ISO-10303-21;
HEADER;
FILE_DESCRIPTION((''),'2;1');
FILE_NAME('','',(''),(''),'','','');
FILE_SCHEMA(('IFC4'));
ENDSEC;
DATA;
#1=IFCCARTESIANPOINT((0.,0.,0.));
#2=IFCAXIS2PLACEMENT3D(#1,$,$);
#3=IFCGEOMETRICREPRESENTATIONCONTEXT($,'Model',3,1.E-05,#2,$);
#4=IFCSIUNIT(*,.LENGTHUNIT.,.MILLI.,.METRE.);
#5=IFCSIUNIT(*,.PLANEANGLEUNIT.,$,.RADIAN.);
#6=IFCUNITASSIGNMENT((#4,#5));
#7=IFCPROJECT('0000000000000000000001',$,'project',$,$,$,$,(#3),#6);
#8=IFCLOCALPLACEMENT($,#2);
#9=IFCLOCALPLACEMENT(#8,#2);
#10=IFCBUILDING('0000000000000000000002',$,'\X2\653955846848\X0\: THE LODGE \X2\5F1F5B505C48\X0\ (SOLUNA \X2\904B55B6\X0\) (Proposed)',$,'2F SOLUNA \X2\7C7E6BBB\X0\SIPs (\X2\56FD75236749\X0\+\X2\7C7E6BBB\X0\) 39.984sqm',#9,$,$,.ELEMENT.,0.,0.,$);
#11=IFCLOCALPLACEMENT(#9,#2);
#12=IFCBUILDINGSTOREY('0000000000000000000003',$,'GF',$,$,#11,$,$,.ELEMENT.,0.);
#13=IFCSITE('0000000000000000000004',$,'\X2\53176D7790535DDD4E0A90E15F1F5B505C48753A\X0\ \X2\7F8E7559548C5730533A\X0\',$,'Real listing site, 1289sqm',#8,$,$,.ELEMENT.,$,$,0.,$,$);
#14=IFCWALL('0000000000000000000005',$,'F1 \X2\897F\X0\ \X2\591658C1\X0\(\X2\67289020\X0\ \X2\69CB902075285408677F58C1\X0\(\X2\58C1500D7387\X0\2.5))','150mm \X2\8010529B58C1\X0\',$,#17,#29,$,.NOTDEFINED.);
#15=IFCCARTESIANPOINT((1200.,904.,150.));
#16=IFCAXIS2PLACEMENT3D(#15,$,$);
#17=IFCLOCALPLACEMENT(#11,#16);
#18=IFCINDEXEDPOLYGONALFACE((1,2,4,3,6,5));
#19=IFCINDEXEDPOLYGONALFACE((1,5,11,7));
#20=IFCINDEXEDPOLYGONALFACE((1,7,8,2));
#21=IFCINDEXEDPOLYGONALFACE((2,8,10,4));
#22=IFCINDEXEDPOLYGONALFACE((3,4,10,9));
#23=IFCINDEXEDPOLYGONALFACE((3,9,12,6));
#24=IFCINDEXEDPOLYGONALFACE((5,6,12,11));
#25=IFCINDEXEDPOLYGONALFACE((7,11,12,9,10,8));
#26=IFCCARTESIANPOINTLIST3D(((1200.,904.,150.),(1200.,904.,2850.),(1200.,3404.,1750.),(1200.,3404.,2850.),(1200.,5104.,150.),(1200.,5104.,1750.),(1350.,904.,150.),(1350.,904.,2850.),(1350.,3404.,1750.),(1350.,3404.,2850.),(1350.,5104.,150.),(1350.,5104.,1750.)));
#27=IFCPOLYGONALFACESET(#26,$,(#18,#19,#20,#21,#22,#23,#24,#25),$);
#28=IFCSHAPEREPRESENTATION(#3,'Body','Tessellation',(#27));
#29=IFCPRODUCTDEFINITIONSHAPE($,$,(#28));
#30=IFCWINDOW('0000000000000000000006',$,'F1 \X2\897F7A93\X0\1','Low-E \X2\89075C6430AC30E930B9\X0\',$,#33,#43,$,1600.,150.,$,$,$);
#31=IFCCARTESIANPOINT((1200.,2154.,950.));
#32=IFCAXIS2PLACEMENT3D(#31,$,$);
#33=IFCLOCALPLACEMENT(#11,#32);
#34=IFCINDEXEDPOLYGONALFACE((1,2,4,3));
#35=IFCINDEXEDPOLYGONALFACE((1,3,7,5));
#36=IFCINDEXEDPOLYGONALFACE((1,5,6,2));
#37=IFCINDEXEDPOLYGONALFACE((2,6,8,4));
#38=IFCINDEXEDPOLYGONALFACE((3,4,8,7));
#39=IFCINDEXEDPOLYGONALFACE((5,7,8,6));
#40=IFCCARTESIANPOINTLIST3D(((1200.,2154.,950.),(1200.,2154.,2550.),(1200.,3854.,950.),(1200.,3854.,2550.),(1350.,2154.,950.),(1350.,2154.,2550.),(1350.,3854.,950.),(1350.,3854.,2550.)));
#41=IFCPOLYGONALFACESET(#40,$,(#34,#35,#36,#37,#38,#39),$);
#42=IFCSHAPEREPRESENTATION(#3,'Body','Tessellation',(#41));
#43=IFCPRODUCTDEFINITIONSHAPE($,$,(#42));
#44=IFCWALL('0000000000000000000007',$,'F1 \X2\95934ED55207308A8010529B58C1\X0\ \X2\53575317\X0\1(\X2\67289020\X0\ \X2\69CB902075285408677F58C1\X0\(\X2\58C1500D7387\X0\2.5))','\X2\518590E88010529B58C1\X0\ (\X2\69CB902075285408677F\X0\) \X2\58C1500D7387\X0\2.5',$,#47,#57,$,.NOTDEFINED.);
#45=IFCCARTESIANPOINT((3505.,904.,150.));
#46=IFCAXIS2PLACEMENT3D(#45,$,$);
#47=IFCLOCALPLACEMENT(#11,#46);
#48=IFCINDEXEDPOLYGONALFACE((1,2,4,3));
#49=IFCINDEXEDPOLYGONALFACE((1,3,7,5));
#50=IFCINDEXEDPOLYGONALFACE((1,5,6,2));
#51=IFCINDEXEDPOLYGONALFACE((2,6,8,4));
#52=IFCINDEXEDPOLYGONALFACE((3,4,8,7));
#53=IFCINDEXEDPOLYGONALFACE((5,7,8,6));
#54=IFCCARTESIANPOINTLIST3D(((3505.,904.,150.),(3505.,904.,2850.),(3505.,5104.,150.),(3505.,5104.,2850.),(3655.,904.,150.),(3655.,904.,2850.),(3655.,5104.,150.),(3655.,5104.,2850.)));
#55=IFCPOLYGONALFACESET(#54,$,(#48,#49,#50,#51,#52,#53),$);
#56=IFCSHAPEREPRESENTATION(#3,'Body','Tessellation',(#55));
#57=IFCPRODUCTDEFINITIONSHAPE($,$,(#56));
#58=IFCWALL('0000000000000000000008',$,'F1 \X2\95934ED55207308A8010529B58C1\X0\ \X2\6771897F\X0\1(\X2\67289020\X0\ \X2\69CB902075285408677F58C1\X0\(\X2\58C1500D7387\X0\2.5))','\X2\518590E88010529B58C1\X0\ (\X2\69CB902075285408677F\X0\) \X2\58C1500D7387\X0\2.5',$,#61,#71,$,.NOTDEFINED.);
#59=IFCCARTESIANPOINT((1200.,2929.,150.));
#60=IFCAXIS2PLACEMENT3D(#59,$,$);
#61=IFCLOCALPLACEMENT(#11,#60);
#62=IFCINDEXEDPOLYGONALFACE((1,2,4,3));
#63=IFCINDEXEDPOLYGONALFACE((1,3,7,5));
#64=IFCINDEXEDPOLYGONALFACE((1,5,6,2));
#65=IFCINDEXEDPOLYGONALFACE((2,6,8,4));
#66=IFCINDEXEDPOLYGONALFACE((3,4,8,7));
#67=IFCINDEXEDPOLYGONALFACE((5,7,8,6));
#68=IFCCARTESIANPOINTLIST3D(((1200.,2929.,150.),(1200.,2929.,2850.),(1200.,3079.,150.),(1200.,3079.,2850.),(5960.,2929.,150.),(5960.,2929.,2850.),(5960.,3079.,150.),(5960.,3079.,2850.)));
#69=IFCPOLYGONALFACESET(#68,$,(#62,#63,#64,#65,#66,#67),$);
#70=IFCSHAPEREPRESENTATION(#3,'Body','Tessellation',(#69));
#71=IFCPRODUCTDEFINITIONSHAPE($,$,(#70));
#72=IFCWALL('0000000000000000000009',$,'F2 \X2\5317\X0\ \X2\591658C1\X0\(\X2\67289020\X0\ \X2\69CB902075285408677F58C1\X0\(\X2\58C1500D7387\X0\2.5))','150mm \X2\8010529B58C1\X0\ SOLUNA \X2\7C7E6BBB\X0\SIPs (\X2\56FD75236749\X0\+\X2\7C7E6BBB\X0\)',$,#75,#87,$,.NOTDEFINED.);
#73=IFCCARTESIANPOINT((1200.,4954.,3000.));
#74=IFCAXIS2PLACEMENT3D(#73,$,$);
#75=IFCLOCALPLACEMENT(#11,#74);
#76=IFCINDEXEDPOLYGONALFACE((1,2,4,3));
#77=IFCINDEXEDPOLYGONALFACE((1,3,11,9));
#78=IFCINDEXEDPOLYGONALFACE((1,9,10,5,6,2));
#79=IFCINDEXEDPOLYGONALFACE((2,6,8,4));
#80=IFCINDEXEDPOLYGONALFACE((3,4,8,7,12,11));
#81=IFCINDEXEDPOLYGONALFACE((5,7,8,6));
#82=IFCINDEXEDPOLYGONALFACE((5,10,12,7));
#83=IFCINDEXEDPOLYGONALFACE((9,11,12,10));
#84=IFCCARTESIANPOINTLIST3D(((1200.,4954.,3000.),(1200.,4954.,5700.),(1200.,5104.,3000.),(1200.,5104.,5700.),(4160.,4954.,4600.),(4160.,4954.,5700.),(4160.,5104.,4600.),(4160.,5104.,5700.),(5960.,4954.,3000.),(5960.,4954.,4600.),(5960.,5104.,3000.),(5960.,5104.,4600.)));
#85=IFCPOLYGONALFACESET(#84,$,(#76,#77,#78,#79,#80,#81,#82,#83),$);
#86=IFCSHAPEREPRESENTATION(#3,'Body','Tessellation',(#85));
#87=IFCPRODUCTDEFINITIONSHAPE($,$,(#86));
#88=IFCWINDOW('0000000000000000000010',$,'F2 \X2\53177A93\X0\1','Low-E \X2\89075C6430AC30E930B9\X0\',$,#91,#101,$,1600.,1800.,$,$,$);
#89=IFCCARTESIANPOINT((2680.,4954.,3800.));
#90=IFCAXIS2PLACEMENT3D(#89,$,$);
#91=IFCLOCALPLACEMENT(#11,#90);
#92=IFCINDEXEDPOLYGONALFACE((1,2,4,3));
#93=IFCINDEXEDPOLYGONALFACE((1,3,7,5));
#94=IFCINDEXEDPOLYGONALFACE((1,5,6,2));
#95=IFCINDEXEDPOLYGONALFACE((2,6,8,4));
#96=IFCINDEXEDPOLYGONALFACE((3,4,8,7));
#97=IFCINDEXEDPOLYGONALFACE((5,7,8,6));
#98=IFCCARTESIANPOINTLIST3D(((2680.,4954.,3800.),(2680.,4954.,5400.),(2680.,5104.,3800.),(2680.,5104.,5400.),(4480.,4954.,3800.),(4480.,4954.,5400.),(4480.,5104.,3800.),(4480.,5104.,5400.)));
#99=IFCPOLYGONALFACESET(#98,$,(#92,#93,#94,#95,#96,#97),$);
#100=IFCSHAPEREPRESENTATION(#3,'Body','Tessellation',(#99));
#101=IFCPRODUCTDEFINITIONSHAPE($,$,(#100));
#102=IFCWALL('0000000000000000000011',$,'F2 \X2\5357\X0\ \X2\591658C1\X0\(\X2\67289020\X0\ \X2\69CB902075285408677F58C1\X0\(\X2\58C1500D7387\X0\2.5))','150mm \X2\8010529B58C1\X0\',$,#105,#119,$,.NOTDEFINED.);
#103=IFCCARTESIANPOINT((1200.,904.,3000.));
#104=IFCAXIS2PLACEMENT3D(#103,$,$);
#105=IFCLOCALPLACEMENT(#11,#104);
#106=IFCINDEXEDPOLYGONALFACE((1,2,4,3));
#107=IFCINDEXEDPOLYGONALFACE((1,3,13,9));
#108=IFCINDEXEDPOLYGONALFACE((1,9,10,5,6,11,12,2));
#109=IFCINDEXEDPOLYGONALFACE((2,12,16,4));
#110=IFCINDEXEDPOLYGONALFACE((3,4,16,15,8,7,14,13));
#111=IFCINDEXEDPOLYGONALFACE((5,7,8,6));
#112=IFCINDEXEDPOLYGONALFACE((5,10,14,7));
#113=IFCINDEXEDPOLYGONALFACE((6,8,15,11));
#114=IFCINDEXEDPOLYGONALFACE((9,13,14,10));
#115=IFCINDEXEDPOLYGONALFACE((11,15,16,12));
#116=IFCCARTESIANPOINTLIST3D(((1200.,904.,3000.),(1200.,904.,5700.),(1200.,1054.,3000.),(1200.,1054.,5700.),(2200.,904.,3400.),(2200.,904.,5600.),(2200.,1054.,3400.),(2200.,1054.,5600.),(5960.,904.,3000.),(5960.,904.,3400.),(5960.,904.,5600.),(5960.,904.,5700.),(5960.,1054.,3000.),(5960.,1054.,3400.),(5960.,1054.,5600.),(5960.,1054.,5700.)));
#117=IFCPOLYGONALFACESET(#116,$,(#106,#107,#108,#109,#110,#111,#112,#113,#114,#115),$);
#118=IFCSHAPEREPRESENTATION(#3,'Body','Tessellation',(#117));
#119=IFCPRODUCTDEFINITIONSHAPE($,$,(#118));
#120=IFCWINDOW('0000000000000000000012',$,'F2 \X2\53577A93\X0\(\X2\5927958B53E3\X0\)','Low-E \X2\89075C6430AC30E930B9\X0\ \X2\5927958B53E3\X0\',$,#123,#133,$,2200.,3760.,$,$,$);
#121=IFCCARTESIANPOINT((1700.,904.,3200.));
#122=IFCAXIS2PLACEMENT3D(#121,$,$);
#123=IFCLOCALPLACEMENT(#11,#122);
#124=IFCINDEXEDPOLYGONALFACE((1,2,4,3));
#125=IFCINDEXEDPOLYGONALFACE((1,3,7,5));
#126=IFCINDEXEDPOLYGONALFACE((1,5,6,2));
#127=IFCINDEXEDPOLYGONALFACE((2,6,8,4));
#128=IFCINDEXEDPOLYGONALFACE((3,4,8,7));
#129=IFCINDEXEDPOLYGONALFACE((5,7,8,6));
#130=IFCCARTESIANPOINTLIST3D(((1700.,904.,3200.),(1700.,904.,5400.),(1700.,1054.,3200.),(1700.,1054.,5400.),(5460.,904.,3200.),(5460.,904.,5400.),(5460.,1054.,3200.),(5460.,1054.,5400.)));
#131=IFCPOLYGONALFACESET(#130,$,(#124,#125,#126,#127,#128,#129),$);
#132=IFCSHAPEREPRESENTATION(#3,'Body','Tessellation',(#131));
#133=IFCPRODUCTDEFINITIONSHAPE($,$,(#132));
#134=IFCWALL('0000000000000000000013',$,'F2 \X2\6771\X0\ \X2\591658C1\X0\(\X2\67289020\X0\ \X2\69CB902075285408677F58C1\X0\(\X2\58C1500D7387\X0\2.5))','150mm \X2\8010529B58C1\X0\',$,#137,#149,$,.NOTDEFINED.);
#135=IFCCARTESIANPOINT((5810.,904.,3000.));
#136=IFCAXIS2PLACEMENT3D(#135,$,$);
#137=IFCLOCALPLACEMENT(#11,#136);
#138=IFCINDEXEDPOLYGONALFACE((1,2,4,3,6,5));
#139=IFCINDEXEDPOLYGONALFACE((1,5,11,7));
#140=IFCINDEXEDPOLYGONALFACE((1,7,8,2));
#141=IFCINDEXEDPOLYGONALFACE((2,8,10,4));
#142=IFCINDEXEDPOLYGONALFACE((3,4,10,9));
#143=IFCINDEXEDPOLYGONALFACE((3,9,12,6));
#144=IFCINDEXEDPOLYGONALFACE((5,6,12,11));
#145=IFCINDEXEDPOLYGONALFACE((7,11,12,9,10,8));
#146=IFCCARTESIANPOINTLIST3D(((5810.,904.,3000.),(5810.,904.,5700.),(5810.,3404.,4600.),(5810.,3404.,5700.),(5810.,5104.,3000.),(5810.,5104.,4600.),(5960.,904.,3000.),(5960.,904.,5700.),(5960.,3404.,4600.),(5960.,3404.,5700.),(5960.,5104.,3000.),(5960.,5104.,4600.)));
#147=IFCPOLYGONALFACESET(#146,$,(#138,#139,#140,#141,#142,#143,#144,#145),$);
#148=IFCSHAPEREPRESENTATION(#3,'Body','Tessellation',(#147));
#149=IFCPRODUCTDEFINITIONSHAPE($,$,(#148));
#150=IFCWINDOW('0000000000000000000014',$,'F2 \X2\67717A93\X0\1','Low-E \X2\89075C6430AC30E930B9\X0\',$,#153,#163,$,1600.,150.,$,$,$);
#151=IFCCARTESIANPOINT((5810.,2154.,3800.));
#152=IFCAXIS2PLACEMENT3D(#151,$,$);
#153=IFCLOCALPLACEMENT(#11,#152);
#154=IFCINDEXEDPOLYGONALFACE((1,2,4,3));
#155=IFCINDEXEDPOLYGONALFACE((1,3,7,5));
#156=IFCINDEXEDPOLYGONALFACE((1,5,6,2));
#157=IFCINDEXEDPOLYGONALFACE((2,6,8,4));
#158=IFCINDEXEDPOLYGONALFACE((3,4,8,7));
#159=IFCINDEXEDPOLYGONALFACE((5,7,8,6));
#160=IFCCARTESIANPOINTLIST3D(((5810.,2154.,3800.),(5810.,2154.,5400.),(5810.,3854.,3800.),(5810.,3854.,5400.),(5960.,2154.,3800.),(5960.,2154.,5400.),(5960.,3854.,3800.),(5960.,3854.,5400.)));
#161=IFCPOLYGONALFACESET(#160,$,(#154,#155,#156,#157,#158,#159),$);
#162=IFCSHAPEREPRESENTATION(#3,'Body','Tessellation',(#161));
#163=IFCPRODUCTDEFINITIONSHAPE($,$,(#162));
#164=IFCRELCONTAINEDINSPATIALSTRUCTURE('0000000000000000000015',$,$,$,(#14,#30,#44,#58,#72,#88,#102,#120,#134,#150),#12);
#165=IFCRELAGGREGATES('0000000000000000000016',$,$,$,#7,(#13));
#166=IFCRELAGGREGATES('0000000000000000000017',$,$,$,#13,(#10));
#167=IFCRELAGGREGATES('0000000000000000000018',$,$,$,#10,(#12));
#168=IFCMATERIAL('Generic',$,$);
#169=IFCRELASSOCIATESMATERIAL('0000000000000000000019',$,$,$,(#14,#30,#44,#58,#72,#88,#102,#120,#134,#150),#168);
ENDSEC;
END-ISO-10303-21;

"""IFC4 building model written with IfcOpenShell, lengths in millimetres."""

from ifc_helpers import new_model, si_unit, frame, frame_2d, origin, place, context, project, spatial, rectangle, extrude, material, element, fill, save


model = new_model("IFC4")

# Units and contexts
model_context = context("Model", 3, precision=1e-05, world=origin())
ifc_project = project(units=[si_unit("LENGTHUNIT", "METRE", prefix="MILLI"), si_unit("PLANEANGLEUNIT", "RADIAN")], contexts=[model_context])

# Site, building, storey
site_placement = place(None, origin())
site = spatial("IfcSite", under=ifc_project, at=site_placement, Name="北海道川上郡弟子屈町 美留和地区", ObjectType="Real listing site, 1289sqm", CompositionType="ELEMENT", RefElevation=0.0)
building_placement = place(site_placement, origin())
building = spatial("IfcBuilding", under=site, at=building_placement, Name="改善案: THE LODGE 弟子屈 (SOLUNA 運営) (Proposed)", ObjectType="2F SOLUNA 籾殻SIPs (国産杉+籾殻) 39.984sqm", CompositionType="ELEMENT", ElevationOfRefHeight=0.0, ElevationOfTerrain=0.0)
storey_placement = place(building_placement, origin())
storey = spatial("IfcBuildingStorey", under=building, at=storey_placement, Name="GF", CompositionType="ELEMENT", Elevation=0.0)

# Shared definitions
ifc_material_1 = material(Name="Generic")

# Wall, opening, window
wall_1_placement = place(storey_placement, frame((1200.0, 904.0, 150.0)))
wall_1 = element("IfcWall", 1, at=wall_1_placement, inside=storey, material=ifc_material_1, Name="F1 西 外壁(木造 構造用合板壁(壁倍率2.5))", Description="150mm 耐力壁", PredefinedType="NOTDEFINED", context=model_context, shape_type="SweptSolid", body=[
    extrude(rectangle(XDim=150.0, YDim=4200.0, at=frame_2d((75.0, 2100.0))), frame((1200.0, 904.0, 150.0)), (0.0, 0.0, 1.0), 2700.0),
])
opening_1_placement = place(storey_placement, frame((1200.0, 2154.0, 950.0)))
opening_1 = element("IfcOpeningElement", 2, at=opening_1_placement, cuts=wall_1, PredefinedType="NOTDEFINED", context=model_context, shape_type="SweptSolid", body=[
    extrude(rectangle(XDim=150.0, YDim=1700.0, at=frame_2d((75.0, 850.0))), frame((1200.0, 2154.0, 950.0)), (0.0, 0.0, 1.0), 1600.0),
])
window_1_placement = place(storey_placement, frame((1200.0, 2154.0, 950.0)))
window_1 = element("IfcWindow", 3, at=window_1_placement, inside=storey, material=ifc_material_1, Name="F1 西窓1", Description="Low-E 複層ガラス", OverallHeight=1600.0, OverallWidth=150.0, context=model_context, shape_type="SweptSolid", body=[
    extrude(rectangle(XDim=150.0, YDim=1700.0, at=frame_2d((75.0, 850.0))), frame((1200.0, 2154.0, 950.0)), (0.0, 0.0, 1.0), 1600.0),
])
fill(opening_1, window_1)

# Walls
wall_2_placement = place(storey_placement, frame((3505.0, 904.0, 150.0)))
element("IfcWall", 4, at=wall_2_placement, inside=storey, material=ifc_material_1, Name="F1 間仕切り耐力壁 南北1(木造 構造用合板壁(壁倍率2.5))", Description="内部耐力壁 (構造用合板) 壁倍率2.5", PredefinedType="NOTDEFINED", context=model_context, shape_type="SweptSolid", body=[
    extrude(rectangle(XDim=150.0, YDim=4200.0, at=frame_2d((75.0, 2100.0))), frame((3505.0, 904.0, 150.0)), (0.0, 0.0, 1.0), 2700.0),
])
wall_3_placement = place(storey_placement, frame((1200.0, 2929.0, 150.0)))
element("IfcWall", 5, at=wall_3_placement, inside=storey, material=ifc_material_1, Name="F1 間仕切り耐力壁 東西1(木造 構造用合板壁(壁倍率2.5))", Description="内部耐力壁 (構造用合板) 壁倍率2.5", PredefinedType="NOTDEFINED", context=model_context, shape_type="SweptSolid", body=[
    extrude(rectangle(XDim=4760.0, YDim=150.0, at=frame_2d((2380.0, 75.0))), frame((1200.0, 2929.0, 150.0)), (0.0, 0.0, 1.0), 2700.0),
])

# Walls, openings, windows
wall_4_placement = place(storey_placement, frame((1200.0, 4954.0, 3000.0)))
wall_4 = element("IfcWall", 6, at=wall_4_placement, inside=storey, material=ifc_material_1, Name="F2 北 外壁(木造 構造用合板壁(壁倍率2.5))", Description="150mm 耐力壁 SOLUNA 籾殻SIPs (国産杉+籾殻)", PredefinedType="NOTDEFINED", context=model_context, shape_type="SweptSolid", body=[
    extrude(rectangle(XDim=4760.0, YDim=150.0, at=frame_2d((2380.0, 75.0))), frame((1200.0, 4954.0, 3000.0)), (0.0, 0.0, 1.0), 2700.0),
])
opening_2_placement = place(storey_placement, frame((2680.0, 4954.0, 3800.0)))
opening_2 = element("IfcOpeningElement", 7, at=opening_2_placement, cuts=wall_4, PredefinedType="NOTDEFINED", context=model_context, shape_type="SweptSolid", body=[
    extrude(rectangle(XDim=1800.0, YDim=150.0, at=frame_2d((900.0, 75.0))), frame((2680.0, 4954.0, 3800.0)), (0.0, 0.0, 1.0), 1600.0),
])
window_2_placement = place(storey_placement, frame((2680.0, 4954.0, 3800.0)))
window_2 = element("IfcWindow", 8, at=window_2_placement, inside=storey, material=ifc_material_1, Name="F2 北窓1", Description="Low-E 複層ガラス", OverallHeight=1600.0, OverallWidth=1800.0, context=model_context, shape_type="SweptSolid", body=[
    extrude(rectangle(XDim=1800.0, YDim=150.0, at=frame_2d((900.0, 75.0))), frame((2680.0, 4954.0, 3800.0)), (0.0, 0.0, 1.0), 1600.0),
])
fill(opening_2, window_2)
wall_5_placement = place(storey_placement, frame((1200.0, 904.0, 3000.0)))
wall_5 = element("IfcWall", 9, at=wall_5_placement, inside=storey, material=ifc_material_1, Name="F2 南 外壁(木造 構造用合板壁(壁倍率2.5))", Description="150mm 耐力壁", PredefinedType="NOTDEFINED", context=model_context, shape_type="SweptSolid", body=[
    extrude(rectangle(XDim=4760.0, YDim=150.0, at=frame_2d((2380.0, 75.0))), frame((1200.0, 904.0, 3000.0)), (0.0, 0.0, 1.0), 2700.0),
])
opening_3_placement = place(storey_placement, frame((1700.0, 904.0, 3200.0)))
opening_3 = element("IfcOpeningElement", 10, at=opening_3_placement, cuts=wall_5, PredefinedType="NOTDEFINED", context=model_context, shape_type="SweptSolid", body=[
    extrude(rectangle(XDim=3760.0, YDim=150.0, at=frame_2d((1880.0, 75.0))), frame((1700.0, 904.0, 3200.0)), (0.0, 0.0, 1.0), 2200.0),
])
window_3_placement = place(storey_placement, frame((1700.0, 904.0, 3200.0)))
window_3 = element("IfcWindow", 11, at=window_3_placement, inside=storey, material=ifc_material_1, Name="F2 南窓(大開口)", Description="Low-E 複層ガラス 大開口", OverallHeight=2200.0, OverallWidth=3760.0, context=model_context, shape_type="SweptSolid", body=[
    extrude(rectangle(XDim=3760.0, YDim=150.0, at=frame_2d((1880.0, 75.0))), frame((1700.0, 904.0, 3200.0)), (0.0, 0.0, 1.0), 2200.0),
])
fill(opening_3, window_3)
wall_6_placement = place(storey_placement, frame((5810.0, 904.0, 3000.0)))
wall_6 = element("IfcWall", 12, at=wall_6_placement, inside=storey, material=ifc_material_1, Name="F2 東 外壁(木造 構造用合板壁(壁倍率2.5))", Description="150mm 耐力壁", PredefinedType="NOTDEFINED", context=model_context, shape_type="SweptSolid", body=[
    extrude(rectangle(XDim=150.0, YDim=4200.0, at=frame_2d((75.0, 2100.0))), frame((5810.0, 904.0, 3000.0)), (0.0, 0.0, 1.0), 2700.0),
])
opening_4_placement = place(storey_placement, frame((5810.0, 2154.0, 3800.0)))
opening_4 = element("IfcOpeningElement", 13, at=opening_4_placement, cuts=wall_6, PredefinedType="NOTDEFINED", context=model_context, shape_type="SweptSolid", body=[
    extrude(rectangle(XDim=150.0, YDim=1700.0, at=frame_2d((75.0, 850.0))), frame((5810.0, 2154.0, 3800.0)), (0.0, 0.0, 1.0), 1600.0),
])
window_4_placement = place(storey_placement, frame((5810.0, 2154.0, 3800.0)))
window_4 = element("IfcWindow", 14, at=window_4_placement, inside=storey, material=ifc_material_1, Name="F2 東窓1", Description="Low-E 複層ガラス", OverallHeight=1600.0, OverallWidth=150.0, context=model_context, shape_type="SweptSolid", body=[
    extrude(rectangle(XDim=150.0, YDim=1700.0, at=frame_2d((75.0, 850.0))), frame((5810.0, 2154.0, 3800.0)), (0.0, 0.0, 1.0), 1600.0),
])
fill(opening_4, window_4)

save(model, "model.ifc")
